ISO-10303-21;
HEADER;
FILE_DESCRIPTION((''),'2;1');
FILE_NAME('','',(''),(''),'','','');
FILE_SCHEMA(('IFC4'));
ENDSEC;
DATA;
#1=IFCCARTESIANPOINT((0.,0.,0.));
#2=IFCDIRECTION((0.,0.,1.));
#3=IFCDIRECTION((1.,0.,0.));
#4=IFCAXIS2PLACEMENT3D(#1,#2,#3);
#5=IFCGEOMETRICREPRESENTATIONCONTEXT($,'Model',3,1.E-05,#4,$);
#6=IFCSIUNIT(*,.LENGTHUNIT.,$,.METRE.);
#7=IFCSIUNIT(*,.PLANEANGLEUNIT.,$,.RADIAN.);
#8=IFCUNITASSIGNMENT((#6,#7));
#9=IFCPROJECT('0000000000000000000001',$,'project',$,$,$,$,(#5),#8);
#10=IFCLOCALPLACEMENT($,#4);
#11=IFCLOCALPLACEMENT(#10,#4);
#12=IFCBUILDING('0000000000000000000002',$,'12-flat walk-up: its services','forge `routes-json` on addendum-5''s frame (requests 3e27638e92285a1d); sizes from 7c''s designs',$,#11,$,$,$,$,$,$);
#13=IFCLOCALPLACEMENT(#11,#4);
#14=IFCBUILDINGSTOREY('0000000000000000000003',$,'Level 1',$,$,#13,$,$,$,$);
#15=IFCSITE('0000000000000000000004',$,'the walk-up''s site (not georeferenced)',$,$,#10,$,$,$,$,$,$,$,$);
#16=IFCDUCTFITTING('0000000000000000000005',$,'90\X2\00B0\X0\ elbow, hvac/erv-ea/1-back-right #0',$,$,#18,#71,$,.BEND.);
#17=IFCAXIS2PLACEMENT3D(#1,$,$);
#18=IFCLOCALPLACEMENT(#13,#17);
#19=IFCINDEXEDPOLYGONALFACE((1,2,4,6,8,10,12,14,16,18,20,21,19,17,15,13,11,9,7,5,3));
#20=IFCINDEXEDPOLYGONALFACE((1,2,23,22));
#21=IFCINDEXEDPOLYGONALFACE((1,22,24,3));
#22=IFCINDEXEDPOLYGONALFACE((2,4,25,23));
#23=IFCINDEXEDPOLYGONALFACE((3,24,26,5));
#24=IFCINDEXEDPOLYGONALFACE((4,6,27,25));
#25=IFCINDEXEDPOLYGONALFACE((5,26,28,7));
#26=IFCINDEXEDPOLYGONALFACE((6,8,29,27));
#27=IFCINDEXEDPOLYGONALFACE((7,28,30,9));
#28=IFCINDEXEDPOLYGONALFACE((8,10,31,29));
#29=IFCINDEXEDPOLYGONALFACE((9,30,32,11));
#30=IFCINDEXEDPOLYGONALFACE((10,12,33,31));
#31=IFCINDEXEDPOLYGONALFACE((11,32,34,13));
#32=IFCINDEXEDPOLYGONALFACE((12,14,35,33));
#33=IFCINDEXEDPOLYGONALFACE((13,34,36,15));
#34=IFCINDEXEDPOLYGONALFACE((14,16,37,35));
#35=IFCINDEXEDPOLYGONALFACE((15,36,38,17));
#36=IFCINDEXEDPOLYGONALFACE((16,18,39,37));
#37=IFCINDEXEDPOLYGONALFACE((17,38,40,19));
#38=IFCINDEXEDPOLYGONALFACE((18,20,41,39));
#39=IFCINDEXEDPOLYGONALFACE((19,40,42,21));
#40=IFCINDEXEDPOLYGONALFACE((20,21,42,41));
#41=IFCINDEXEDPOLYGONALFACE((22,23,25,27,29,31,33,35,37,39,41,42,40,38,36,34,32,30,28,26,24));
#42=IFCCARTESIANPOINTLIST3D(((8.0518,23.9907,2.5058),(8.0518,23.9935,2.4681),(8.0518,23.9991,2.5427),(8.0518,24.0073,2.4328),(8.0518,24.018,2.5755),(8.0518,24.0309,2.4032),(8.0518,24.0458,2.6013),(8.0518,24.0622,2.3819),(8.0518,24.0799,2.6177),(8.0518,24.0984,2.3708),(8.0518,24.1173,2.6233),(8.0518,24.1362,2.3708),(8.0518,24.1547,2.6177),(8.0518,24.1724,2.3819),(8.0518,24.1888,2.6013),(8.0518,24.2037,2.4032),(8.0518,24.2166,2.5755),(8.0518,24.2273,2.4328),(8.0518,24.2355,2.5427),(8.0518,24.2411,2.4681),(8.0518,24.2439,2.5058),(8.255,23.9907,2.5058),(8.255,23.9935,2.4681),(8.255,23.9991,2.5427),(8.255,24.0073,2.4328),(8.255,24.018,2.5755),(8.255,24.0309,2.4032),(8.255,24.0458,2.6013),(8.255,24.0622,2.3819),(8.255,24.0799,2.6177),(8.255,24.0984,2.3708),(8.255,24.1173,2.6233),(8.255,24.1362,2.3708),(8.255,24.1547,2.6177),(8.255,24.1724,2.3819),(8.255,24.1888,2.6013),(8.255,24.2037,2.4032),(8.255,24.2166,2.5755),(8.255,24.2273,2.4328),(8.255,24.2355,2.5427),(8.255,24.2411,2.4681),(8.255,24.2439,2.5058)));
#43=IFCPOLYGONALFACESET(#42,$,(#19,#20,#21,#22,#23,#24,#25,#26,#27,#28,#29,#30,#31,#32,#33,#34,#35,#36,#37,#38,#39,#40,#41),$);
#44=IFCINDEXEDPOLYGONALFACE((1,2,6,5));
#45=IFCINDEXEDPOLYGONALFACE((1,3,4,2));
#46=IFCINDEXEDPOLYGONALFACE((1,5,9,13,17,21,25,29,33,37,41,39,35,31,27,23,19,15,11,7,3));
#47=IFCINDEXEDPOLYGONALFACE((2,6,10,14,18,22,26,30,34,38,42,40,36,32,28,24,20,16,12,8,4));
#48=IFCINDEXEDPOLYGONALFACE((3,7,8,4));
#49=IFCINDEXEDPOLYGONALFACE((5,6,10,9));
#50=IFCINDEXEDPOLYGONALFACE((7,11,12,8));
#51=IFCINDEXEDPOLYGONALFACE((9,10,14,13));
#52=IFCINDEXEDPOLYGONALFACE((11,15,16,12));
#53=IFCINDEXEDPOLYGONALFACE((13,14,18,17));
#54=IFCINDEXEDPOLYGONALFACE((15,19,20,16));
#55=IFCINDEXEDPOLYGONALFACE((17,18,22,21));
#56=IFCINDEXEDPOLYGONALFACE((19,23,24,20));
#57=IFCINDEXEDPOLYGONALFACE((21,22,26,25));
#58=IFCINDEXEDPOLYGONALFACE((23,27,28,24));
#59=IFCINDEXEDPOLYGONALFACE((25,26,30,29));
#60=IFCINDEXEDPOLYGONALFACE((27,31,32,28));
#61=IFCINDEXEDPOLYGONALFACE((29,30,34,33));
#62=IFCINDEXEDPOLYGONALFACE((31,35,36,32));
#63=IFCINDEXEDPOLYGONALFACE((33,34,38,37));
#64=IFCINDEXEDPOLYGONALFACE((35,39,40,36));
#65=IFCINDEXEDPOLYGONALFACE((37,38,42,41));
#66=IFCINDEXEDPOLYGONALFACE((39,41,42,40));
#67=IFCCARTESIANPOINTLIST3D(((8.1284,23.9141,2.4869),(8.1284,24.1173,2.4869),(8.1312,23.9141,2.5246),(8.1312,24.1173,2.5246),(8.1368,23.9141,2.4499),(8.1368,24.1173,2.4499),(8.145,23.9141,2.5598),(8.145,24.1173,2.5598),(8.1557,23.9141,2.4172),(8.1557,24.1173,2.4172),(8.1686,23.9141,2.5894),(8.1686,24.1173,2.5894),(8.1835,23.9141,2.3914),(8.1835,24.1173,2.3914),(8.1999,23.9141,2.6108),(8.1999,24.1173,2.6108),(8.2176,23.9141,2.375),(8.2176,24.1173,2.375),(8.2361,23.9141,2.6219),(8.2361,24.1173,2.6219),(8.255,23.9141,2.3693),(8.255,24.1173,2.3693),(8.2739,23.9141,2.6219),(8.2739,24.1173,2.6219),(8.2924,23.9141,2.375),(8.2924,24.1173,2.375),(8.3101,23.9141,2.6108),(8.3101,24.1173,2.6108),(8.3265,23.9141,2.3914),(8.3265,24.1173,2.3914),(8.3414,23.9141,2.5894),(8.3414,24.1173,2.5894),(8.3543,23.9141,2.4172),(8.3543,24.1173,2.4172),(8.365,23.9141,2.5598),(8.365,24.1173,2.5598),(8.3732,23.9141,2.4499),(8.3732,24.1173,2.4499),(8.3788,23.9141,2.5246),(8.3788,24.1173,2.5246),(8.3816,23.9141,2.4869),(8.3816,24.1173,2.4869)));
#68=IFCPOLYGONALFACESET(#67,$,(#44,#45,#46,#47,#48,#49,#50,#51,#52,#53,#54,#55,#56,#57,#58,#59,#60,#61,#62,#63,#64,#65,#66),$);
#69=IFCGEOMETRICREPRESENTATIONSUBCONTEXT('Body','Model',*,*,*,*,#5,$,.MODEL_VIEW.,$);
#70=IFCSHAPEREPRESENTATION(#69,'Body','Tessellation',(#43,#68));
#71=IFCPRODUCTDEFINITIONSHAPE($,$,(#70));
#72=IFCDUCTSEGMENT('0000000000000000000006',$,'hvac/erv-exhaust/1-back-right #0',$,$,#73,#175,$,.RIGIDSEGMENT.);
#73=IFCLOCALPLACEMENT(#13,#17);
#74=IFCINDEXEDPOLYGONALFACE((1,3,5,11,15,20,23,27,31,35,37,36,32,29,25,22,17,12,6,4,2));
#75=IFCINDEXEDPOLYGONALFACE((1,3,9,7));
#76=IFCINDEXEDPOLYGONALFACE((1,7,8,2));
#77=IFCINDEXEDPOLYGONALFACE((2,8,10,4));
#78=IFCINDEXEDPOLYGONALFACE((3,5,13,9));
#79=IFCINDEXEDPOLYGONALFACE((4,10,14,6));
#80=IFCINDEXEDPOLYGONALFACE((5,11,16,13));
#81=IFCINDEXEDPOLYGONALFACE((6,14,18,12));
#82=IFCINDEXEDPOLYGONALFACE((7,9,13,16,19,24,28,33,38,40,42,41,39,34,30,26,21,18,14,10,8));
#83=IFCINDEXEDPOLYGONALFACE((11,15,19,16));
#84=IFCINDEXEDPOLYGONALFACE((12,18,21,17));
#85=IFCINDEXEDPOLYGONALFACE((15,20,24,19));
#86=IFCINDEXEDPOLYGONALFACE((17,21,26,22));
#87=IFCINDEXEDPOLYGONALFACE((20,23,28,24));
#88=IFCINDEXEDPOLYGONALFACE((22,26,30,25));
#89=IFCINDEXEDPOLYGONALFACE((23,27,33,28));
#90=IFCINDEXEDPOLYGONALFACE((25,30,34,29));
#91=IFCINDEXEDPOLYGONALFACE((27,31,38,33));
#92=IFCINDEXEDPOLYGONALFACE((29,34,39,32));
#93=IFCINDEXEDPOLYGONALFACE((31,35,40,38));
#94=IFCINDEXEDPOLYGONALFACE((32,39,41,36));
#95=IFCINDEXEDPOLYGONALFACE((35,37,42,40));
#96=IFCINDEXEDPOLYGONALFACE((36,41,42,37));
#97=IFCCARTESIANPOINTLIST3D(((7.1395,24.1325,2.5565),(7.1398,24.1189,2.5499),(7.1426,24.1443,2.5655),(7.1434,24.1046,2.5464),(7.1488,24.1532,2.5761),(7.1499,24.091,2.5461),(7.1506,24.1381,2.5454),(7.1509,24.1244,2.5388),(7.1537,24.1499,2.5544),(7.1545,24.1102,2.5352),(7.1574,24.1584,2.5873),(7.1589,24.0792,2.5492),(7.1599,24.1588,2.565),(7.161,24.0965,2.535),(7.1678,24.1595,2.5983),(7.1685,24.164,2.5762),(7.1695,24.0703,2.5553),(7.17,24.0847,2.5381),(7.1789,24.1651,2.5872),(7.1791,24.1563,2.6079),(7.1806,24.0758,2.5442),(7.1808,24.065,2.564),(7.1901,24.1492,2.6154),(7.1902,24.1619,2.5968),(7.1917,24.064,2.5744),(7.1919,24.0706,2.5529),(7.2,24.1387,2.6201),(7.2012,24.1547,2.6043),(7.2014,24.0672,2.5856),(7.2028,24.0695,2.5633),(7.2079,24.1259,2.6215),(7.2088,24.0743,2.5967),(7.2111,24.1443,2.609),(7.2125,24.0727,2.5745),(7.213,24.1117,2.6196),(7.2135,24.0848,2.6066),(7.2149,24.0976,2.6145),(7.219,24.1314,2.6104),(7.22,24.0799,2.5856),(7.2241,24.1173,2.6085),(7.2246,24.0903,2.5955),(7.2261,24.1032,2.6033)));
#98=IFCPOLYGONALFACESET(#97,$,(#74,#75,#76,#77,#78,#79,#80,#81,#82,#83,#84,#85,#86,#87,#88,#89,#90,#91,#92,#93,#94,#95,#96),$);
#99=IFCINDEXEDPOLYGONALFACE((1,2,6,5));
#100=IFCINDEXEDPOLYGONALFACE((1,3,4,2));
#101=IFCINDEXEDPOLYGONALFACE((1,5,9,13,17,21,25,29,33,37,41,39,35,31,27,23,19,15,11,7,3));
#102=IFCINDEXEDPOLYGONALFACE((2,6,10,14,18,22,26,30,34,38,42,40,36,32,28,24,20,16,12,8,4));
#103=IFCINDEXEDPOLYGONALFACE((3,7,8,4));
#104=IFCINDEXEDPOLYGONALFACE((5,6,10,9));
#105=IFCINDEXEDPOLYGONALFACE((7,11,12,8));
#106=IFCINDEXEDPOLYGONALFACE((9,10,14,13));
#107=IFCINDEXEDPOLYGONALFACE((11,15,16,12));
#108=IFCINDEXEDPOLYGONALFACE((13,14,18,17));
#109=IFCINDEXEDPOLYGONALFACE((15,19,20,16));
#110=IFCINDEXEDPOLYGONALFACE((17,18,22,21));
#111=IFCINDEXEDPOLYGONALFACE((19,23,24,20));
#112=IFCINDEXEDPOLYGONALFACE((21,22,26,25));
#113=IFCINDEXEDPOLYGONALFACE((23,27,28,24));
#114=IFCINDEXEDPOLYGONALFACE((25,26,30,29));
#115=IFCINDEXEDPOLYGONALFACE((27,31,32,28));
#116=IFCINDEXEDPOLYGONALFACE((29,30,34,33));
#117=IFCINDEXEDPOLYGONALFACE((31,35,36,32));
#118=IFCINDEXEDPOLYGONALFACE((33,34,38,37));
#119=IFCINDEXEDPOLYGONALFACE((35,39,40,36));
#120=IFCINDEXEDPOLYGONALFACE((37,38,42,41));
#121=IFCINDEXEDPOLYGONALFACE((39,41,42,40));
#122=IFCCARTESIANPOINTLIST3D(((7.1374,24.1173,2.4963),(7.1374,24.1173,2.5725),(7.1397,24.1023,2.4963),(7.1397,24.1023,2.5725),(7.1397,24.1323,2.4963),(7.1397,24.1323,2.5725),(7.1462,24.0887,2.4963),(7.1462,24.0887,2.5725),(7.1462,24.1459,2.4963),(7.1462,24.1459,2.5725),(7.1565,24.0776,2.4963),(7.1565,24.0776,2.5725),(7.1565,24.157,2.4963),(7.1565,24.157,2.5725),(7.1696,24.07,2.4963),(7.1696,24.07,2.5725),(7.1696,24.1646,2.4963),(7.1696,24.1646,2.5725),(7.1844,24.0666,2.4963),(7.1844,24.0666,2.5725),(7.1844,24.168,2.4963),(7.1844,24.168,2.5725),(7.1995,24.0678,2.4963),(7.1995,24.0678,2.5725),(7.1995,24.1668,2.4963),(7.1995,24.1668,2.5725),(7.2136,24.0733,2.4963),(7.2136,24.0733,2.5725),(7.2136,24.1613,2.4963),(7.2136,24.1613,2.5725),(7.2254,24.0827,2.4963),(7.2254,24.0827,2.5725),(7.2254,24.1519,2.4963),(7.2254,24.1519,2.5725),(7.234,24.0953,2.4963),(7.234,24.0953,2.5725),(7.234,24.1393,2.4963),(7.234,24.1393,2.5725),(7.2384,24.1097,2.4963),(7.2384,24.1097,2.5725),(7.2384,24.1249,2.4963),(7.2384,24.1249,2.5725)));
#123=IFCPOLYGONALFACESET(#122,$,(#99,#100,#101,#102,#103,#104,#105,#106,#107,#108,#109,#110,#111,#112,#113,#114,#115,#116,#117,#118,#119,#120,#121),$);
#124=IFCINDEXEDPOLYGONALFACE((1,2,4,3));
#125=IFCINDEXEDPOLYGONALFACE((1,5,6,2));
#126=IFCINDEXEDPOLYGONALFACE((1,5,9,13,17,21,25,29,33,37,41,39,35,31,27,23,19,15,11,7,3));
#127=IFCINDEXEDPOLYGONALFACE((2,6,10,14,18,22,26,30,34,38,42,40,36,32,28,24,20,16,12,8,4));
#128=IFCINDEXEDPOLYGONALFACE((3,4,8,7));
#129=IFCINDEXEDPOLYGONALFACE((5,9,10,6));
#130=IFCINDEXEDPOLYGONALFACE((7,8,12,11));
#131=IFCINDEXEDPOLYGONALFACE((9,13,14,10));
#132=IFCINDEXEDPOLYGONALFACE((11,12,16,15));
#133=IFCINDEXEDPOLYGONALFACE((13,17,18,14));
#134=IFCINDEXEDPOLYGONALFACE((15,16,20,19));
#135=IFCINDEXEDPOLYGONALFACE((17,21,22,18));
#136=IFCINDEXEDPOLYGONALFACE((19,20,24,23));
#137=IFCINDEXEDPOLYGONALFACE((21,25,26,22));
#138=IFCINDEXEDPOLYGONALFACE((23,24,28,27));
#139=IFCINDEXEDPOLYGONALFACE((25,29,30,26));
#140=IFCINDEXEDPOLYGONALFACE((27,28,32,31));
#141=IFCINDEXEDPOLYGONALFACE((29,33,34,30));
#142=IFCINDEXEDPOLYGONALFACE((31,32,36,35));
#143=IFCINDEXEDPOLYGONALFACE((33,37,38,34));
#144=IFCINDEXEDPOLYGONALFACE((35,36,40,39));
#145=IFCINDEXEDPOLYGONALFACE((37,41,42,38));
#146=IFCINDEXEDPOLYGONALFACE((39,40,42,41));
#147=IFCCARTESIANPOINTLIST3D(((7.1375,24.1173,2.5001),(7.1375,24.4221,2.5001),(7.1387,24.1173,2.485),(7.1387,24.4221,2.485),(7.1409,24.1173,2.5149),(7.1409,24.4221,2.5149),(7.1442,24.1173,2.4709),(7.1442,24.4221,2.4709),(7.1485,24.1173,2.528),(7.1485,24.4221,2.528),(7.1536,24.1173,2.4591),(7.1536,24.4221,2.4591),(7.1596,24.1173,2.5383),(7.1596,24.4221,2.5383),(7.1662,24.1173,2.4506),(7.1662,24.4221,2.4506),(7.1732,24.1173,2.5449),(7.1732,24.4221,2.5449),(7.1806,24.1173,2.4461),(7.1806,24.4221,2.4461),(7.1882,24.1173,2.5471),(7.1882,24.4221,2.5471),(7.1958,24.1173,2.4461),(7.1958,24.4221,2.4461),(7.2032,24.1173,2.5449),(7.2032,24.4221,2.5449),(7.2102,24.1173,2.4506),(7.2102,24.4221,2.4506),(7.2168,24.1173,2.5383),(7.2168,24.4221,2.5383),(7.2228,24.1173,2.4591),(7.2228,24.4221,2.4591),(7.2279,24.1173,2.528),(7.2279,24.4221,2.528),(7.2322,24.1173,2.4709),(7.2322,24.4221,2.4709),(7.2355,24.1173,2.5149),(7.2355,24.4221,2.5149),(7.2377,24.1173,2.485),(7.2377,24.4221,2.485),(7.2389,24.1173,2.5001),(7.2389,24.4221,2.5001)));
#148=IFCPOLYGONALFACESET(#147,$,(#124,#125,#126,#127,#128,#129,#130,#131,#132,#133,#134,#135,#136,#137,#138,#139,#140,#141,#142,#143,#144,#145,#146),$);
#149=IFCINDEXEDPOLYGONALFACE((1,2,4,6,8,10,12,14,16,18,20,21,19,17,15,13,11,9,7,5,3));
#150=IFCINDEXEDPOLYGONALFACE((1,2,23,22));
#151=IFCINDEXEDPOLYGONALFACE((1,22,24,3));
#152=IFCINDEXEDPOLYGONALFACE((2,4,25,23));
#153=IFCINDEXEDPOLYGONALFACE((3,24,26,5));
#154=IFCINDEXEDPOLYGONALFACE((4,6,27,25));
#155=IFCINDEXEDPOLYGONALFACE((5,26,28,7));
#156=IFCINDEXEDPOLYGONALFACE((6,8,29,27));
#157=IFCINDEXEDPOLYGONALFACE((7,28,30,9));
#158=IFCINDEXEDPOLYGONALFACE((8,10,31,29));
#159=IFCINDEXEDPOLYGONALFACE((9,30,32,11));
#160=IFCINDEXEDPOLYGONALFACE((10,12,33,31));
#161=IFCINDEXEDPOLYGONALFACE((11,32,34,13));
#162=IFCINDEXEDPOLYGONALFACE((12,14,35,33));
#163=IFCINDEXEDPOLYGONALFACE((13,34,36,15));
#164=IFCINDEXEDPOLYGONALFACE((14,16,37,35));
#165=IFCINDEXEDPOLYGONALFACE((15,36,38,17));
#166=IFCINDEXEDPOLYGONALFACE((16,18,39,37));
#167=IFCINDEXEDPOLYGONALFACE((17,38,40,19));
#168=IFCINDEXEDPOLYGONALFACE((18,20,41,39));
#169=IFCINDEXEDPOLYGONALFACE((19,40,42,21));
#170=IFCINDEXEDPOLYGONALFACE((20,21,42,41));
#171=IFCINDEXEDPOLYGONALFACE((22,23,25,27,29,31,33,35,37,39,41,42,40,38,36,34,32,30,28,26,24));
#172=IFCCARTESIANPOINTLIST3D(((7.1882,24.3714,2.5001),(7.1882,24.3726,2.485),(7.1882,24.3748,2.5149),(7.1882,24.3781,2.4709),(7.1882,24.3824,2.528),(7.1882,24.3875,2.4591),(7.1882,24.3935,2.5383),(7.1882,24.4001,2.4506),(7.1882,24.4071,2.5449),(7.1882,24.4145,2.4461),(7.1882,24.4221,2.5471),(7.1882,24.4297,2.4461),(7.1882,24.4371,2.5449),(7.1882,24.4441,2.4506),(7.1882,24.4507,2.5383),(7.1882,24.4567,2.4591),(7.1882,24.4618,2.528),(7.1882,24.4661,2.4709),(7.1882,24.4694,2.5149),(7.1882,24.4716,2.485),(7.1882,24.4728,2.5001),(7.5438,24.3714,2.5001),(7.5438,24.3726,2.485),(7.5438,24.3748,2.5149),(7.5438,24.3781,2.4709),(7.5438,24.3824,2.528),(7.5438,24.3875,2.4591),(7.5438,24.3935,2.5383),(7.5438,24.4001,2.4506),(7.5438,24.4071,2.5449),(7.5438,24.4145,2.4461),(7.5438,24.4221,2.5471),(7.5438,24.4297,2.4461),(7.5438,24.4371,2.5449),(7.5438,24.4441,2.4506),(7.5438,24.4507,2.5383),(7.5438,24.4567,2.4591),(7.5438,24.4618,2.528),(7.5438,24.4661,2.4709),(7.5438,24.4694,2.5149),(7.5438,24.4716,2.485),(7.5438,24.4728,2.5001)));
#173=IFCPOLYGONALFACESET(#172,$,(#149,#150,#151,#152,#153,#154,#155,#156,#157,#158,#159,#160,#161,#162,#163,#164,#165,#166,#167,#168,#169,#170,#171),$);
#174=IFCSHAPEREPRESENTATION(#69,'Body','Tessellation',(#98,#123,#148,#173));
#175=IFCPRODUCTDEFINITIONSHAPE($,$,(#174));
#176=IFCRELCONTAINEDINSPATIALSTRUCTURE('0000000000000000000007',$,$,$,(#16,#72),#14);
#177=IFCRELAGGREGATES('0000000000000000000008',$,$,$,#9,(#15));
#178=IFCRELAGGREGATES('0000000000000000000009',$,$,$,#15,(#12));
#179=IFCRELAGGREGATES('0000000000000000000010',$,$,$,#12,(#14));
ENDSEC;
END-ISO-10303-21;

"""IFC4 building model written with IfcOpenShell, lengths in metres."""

from ifc_helpers import new_model, entity, si_unit, frame, origin_with_axes, place, context, subcontext, project, spatial, element, save


model = new_model("IFC4")

# Units and contexts
model_context = context("Model", 3, precision=1e-05, world=origin_with_axes())
body_context = subcontext(model_context, "Body", "Model", "MODEL_VIEW")
ifc_project = project(units=[si_unit("LENGTHUNIT", "METRE"), si_unit("PLANEANGLEUNIT", "RADIAN")], contexts=[model_context])

# Site, building, storey
site_placement = place(None, origin_with_axes())
site = spatial("IfcSite", under=ifc_project, at=site_placement, Name="the walk-up's site (not georeferenced)")
building_placement = place(site_placement, origin_with_axes())
building = spatial("IfcBuilding", under=site, at=building_placement, Name="12-flat walk-up: its services", Description="forge `routes-json` on addendum-5's frame (requests 3e27638e92285a1d); sizes from 7c's designs")
storey_placement = place(building_placement, origin_with_axes())
storey = spatial("IfcBuildingStorey", under=building, at=storey_placement, Name="Level 1")

# Duct fitting
duct_fitting_1_placement = place(storey_placement, frame((8.0518, 24.1173, 2.4963), z_axis=(0.0, 0.0, 1.0), x_axis=(1.0, 0.0, 0.0)))
element("IfcDuctFitting", 1, at=duct_fitting_1_placement, inside=storey, Name="90° elbow, hvac/erv-ea/1-back-right #0", PredefinedType="BEND", context=body_context, shape_type="AdvancedSweptSolid", body=[
    entity("IfcSweptDiskSolid", entity("IfcPolyline", [entity("IfcCartesianPoint", [0.0, 0.0, 0.0]), entity("IfcCartesianPoint", [0.2032, 0.0, 0.0])]), 0.127),
    entity("IfcSweptDiskSolid", entity("IfcPolyline", [entity("IfcCartesianPoint", [0.2032, 0.0, 0.0]), entity("IfcCartesianPoint", [0.2032, -0.2032, 0.0])]), 0.127),
])

# Duct segment
duct_segment_1_placement = place(storey_placement, frame((7.1771, 24.1117, 2.5837), z_axis=(0.0, 0.0, 1.0), x_axis=(1.0, 0.0, 0.0)))
element("IfcDuctSegment", 2, at=duct_segment_1_placement, inside=storey, Name="hvac/erv-exhaust/1-back-right #0", PredefinedType="RIGIDSEGMENT", context=body_context, shape_type="AdvancedSweptSolid", body=[
    entity("IfcSweptDiskSolid", entity("IfcPolyline", [entity("IfcCartesianPoint", [0.0, 0.0, 0.0]), entity("IfcCartesianPoint", [0.0111, 0.0056, -0.0111])]), 0.0508),
    entity("IfcSweptDiskSolid", entity("IfcPolyline", [entity("IfcCartesianPoint", [0.0111, 0.0056, -0.0111]), entity("IfcCartesianPoint", [0.0111, 0.0056, -0.0873])]), 0.0508),
    entity("IfcSweptDiskSolid", entity("IfcPolyline", [entity("IfcCartesianPoint", [0.0111, 0.0056, -0.0873]), entity("IfcCartesianPoint", [0.0111, 0.3104, -0.0873])]), 0.0508),
    entity("IfcSweptDiskSolid", entity("IfcPolyline", [entity("IfcCartesianPoint", [0.0111, 0.3104, -0.0873]), entity("IfcCartesianPoint", [0.3667, 0.3104, -0.0873])]), 0.0508),
])

save(model, "model.ifc")
